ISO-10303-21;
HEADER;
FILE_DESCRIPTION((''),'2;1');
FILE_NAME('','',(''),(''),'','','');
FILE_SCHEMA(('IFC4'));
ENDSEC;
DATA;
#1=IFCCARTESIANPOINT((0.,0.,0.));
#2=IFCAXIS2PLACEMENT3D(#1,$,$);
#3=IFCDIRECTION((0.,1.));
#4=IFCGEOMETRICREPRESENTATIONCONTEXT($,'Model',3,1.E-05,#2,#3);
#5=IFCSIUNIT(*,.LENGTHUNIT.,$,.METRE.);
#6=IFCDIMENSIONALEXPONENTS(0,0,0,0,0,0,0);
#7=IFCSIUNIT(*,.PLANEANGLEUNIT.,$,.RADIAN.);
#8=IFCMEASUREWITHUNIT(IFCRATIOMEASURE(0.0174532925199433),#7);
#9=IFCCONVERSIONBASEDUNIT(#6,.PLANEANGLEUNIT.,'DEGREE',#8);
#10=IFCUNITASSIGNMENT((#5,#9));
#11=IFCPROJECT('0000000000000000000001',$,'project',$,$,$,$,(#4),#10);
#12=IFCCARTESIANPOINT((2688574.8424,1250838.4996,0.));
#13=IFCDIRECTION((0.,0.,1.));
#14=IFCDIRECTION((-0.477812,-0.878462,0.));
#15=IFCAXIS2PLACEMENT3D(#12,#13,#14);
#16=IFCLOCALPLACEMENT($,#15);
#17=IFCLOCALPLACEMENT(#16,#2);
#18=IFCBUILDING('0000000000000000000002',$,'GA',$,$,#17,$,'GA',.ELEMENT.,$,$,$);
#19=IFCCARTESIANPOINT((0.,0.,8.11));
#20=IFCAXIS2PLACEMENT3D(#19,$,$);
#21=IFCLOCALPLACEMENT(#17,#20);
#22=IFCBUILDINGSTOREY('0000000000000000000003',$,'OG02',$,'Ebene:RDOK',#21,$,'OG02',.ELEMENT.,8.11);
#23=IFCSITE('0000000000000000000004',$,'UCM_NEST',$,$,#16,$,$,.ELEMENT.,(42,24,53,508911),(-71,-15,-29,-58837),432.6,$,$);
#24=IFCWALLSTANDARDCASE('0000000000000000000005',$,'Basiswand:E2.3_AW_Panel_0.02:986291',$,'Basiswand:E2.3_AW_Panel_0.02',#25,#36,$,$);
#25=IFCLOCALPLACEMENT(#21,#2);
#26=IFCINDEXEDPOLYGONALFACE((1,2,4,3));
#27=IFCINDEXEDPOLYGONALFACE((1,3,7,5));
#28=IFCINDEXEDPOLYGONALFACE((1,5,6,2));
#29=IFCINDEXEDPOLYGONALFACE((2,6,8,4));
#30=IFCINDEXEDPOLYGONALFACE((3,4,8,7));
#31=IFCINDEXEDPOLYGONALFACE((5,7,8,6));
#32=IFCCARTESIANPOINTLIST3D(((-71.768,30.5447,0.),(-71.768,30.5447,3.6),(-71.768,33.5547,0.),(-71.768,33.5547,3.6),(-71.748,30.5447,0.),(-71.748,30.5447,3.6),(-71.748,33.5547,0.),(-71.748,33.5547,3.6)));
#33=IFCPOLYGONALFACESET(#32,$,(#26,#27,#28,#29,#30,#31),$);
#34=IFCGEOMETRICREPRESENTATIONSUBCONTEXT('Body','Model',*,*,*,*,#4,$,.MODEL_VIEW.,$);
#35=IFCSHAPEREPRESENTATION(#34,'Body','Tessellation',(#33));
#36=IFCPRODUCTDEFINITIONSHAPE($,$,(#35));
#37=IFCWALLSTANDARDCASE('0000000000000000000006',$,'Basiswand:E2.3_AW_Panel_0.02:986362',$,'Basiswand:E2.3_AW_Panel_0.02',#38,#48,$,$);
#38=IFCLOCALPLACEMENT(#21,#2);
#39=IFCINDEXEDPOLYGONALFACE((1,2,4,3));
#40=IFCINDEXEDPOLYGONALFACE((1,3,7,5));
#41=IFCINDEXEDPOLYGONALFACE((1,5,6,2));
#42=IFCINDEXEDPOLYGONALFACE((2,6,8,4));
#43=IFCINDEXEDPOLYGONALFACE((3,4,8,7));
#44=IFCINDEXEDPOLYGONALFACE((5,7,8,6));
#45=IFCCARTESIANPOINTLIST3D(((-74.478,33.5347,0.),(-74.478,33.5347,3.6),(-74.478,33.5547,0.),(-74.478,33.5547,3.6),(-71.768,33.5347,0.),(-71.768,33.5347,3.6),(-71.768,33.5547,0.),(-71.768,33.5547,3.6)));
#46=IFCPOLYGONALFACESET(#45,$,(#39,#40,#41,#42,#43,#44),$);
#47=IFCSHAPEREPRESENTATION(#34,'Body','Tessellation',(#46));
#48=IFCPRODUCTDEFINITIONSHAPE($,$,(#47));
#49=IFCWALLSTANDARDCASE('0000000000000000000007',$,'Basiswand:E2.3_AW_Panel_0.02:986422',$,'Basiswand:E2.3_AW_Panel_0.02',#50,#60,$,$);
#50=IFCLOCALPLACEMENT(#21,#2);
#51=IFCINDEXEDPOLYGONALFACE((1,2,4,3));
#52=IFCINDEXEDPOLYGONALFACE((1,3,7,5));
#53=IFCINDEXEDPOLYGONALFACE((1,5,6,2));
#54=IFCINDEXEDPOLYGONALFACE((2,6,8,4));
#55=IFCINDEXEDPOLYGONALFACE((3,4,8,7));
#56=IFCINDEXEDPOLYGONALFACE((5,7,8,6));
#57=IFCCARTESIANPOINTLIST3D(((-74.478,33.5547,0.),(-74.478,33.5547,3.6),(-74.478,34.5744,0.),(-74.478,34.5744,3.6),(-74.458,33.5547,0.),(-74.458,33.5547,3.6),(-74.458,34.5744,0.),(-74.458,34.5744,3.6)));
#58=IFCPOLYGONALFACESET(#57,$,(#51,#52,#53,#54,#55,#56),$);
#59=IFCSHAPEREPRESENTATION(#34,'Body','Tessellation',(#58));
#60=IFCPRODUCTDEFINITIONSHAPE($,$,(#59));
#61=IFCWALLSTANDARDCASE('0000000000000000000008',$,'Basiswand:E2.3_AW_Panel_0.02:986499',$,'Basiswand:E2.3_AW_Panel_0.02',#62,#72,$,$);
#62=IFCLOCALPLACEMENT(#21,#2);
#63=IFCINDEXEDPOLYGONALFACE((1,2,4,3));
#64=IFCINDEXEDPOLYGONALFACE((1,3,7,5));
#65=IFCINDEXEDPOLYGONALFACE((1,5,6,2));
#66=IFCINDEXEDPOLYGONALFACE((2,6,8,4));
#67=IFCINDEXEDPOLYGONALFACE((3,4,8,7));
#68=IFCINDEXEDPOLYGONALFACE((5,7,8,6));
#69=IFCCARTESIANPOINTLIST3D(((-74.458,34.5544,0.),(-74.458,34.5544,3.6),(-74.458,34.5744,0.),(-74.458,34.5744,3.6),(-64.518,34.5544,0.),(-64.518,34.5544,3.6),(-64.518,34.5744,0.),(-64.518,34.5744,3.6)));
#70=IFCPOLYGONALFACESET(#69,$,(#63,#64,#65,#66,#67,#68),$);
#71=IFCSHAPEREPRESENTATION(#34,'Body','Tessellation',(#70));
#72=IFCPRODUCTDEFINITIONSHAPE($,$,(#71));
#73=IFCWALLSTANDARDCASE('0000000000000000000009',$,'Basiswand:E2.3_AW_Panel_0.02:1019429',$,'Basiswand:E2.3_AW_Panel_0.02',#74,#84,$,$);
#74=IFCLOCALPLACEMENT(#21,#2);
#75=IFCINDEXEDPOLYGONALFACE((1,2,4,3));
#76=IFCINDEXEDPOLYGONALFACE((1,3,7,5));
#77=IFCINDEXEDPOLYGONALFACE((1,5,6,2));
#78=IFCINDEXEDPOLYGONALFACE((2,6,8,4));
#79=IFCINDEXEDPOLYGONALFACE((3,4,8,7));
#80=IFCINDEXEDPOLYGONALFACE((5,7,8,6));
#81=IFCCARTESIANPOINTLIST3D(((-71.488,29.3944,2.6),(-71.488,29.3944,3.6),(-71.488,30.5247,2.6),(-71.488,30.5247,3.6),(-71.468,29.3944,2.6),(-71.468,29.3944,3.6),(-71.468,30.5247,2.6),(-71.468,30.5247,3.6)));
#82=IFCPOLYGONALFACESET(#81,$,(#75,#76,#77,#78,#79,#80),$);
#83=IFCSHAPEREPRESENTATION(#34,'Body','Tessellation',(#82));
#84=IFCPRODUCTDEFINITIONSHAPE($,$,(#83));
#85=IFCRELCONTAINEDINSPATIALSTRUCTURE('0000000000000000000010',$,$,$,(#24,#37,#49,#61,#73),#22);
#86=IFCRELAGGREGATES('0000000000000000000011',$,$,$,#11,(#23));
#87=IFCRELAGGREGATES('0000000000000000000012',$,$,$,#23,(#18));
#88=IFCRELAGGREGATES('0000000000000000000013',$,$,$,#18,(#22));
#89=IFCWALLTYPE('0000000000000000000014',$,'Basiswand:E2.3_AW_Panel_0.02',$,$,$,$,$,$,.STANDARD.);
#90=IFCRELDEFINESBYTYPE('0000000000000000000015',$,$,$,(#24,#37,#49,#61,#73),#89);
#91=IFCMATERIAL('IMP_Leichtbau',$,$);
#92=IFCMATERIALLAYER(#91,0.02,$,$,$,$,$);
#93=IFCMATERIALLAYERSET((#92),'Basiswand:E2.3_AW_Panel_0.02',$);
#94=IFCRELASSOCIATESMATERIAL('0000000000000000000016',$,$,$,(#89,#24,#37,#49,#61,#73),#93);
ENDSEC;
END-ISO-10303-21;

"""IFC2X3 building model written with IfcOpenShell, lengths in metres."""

from ifc_helpers import new_model, entity, si_unit, converted_unit, direction, frame, frame_2d, origin, place, context, subcontext, project, spatial, rectangle, extrude, material, layer, layer_set, layer_usage, type_object, element, save


model = new_model("IFC2X3")

# Units and contexts
model_context = context("Model", 3, precision=1e-05, world=origin(), true_north=direction((0.0, 1.0)))
body_context = subcontext(model_context, "Body", "Model", "MODEL_VIEW")
ifc_project = project(units=[si_unit("LENGTHUNIT", "METRE"), converted_unit("PLANEANGLEUNIT", "DEGREE", entity("IfcRatioMeasure", 0.0174532925199433), si_unit("PLANEANGLEUNIT", "RADIAN"), dimensions=[0, 0, 0, 0, 0, 0, 0])], contexts=[model_context])

# Site, building, storey
site_placement = place(None, frame((2688574.8424, 1250838.4996, 0.0), z_axis=(0.0, 0.0, 1.0), x_axis=(-0.477812, -0.878462, 0.0)))
site = spatial("IfcSite", under=ifc_project, at=site_placement, Name="UCM_NEST", CompositionType="ELEMENT", RefLatitude=(42, 24, 53, 508911), RefLongitude=(-71, -15, -29, -58837), RefElevation=432.6)
building_placement = place(site_placement, origin())
building = spatial("IfcBuilding", under=site, at=building_placement, Name="GA", LongName="GA", CompositionType="ELEMENT")
storey_placement = place(building_placement, frame((0.0, 0.0, 8.11)))
storey = spatial("IfcBuildingStorey", under=building, at=storey_placement, Name="OG02", ObjectType="Ebene:RDOK", LongName="OG02", CompositionType="ELEMENT", Elevation=8.11)

# Walls
ifc_material_1 = material(Name="IMP_Leichtbau")
ifc_layer_1 = layer(ifc_material_1, 0.02)
ifc_layer_set_1 = layer_set([ifc_layer_1], Name="Basiswand:E2.3_AW_Panel_0.02")
wall_type_1 = type_object("IfcWallType", Name="Basiswand:E2.3_AW_Panel_0.02", PredefinedType="STANDARD", material=ifc_layer_set_1)
ifc_layer_usage_1 = layer_usage(ifc_layer_set_1, "AXIS2", "NEGATIVE", 0.01)
wall_1_placement = place(storey_placement, frame((-71.758, 30.5447, 0.0), z_axis=(0.0, 0.0, 1.0), x_axis=(0.0, 1.0, 0.0)))
element("IfcWallStandardCase", 1, at=wall_1_placement, inside=storey, type_object=wall_type_1, material=ifc_layer_usage_1, Name="Basiswand:E2.3_AW_Panel_0.02:986291", ObjectType="Basiswand:E2.3_AW_Panel_0.02", context=body_context, shape_type="SweptSolid", body=[
    extrude(rectangle(XDim=3.01, YDim=0.02, at=frame_2d((1.505, 0.0), x_axis=(-1.0, 0.0))), origin(), (0.0, 0.0, 1.0), 3.6),
])
ifc_layer_usage_2 = layer_usage(ifc_layer_set_1, "AXIS2", "NEGATIVE", 0.01)
wall_2_placement = place(storey_placement, frame((-71.768, 33.5447, 0.0), z_axis=(0.0, 0.0, 1.0), x_axis=(-1.0, 0.0, 0.0)))
element("IfcWallStandardCase", 2, at=wall_2_placement, inside=storey, type_object=wall_type_1, material=ifc_layer_usage_2, Name="Basiswand:E2.3_AW_Panel_0.02:986362", ObjectType="Basiswand:E2.3_AW_Panel_0.02", context=body_context, shape_type="SweptSolid", body=[
    extrude(rectangle(XDim=2.71, YDim=0.02, at=frame_2d((1.355, 0.0), x_axis=(-1.0, 0.0))), origin(), (0.0, 0.0, 1.0), 3.6),
])
ifc_layer_usage_3 = layer_usage(ifc_layer_set_1, "AXIS2", "NEGATIVE", 0.01)
wall_3_placement = place(storey_placement, frame((-74.468, 33.5547, 0.0), z_axis=(0.0, 0.0, 1.0), x_axis=(0.0, 1.0, 0.0)))
element("IfcWallStandardCase", 3, at=wall_3_placement, inside=storey, type_object=wall_type_1, material=ifc_layer_usage_3, Name="Basiswand:E2.3_AW_Panel_0.02:986422", ObjectType="Basiswand:E2.3_AW_Panel_0.02", context=body_context, shape_type="SweptSolid", body=[
    extrude(rectangle(XDim=1.0198, YDim=0.02, at=frame_2d((0.5099, 0.0), x_axis=(-1.0, 0.0))), origin(), (0.0, 0.0, 1.0), 3.6),
])
ifc_layer_usage_4 = layer_usage(ifc_layer_set_1, "AXIS2", "NEGATIVE", 0.01)
wall_4_placement = place(storey_placement, frame((-74.458, 34.5644, 0.0)))
element("IfcWallStandardCase", 4, at=wall_4_placement, inside=storey, type_object=wall_type_1, material=ifc_layer_usage_4, Name="Basiswand:E2.3_AW_Panel_0.02:986499", ObjectType="Basiswand:E2.3_AW_Panel_0.02", context=body_context, shape_type="SweptSolid", body=[
    extrude(rectangle(XDim=9.94, YDim=0.02, at=frame_2d((4.97, 0.0), x_axis=(-1.0, 0.0))), origin(), (0.0, 0.0, 1.0), 3.6),
])
ifc_layer_usage_5 = layer_usage(ifc_layer_set_1, "AXIS2", "NEGATIVE", 0.01)
wall_5_placement = place(storey_placement, frame((-71.478, 29.3944, 2.6), z_axis=(0.0, 0.0, 1.0), x_axis=(0.0, 1.0, 0.0)))
element("IfcWallStandardCase", 5, at=wall_5_placement, inside=storey, type_object=wall_type_1, material=ifc_layer_usage_5, Name="Basiswand:E2.3_AW_Panel_0.02:1019429", ObjectType="Basiswand:E2.3_AW_Panel_0.02", context=body_context, shape_type="SweptSolid", body=[
    extrude(rectangle(XDim=1.1302, YDim=0.02, at=frame_2d((0.5651, 0.0), x_axis=(-1.0, 0.0))), origin(), (0.0, 0.0, 1.0), 1.0),
])

save(model, "model.ifc")
